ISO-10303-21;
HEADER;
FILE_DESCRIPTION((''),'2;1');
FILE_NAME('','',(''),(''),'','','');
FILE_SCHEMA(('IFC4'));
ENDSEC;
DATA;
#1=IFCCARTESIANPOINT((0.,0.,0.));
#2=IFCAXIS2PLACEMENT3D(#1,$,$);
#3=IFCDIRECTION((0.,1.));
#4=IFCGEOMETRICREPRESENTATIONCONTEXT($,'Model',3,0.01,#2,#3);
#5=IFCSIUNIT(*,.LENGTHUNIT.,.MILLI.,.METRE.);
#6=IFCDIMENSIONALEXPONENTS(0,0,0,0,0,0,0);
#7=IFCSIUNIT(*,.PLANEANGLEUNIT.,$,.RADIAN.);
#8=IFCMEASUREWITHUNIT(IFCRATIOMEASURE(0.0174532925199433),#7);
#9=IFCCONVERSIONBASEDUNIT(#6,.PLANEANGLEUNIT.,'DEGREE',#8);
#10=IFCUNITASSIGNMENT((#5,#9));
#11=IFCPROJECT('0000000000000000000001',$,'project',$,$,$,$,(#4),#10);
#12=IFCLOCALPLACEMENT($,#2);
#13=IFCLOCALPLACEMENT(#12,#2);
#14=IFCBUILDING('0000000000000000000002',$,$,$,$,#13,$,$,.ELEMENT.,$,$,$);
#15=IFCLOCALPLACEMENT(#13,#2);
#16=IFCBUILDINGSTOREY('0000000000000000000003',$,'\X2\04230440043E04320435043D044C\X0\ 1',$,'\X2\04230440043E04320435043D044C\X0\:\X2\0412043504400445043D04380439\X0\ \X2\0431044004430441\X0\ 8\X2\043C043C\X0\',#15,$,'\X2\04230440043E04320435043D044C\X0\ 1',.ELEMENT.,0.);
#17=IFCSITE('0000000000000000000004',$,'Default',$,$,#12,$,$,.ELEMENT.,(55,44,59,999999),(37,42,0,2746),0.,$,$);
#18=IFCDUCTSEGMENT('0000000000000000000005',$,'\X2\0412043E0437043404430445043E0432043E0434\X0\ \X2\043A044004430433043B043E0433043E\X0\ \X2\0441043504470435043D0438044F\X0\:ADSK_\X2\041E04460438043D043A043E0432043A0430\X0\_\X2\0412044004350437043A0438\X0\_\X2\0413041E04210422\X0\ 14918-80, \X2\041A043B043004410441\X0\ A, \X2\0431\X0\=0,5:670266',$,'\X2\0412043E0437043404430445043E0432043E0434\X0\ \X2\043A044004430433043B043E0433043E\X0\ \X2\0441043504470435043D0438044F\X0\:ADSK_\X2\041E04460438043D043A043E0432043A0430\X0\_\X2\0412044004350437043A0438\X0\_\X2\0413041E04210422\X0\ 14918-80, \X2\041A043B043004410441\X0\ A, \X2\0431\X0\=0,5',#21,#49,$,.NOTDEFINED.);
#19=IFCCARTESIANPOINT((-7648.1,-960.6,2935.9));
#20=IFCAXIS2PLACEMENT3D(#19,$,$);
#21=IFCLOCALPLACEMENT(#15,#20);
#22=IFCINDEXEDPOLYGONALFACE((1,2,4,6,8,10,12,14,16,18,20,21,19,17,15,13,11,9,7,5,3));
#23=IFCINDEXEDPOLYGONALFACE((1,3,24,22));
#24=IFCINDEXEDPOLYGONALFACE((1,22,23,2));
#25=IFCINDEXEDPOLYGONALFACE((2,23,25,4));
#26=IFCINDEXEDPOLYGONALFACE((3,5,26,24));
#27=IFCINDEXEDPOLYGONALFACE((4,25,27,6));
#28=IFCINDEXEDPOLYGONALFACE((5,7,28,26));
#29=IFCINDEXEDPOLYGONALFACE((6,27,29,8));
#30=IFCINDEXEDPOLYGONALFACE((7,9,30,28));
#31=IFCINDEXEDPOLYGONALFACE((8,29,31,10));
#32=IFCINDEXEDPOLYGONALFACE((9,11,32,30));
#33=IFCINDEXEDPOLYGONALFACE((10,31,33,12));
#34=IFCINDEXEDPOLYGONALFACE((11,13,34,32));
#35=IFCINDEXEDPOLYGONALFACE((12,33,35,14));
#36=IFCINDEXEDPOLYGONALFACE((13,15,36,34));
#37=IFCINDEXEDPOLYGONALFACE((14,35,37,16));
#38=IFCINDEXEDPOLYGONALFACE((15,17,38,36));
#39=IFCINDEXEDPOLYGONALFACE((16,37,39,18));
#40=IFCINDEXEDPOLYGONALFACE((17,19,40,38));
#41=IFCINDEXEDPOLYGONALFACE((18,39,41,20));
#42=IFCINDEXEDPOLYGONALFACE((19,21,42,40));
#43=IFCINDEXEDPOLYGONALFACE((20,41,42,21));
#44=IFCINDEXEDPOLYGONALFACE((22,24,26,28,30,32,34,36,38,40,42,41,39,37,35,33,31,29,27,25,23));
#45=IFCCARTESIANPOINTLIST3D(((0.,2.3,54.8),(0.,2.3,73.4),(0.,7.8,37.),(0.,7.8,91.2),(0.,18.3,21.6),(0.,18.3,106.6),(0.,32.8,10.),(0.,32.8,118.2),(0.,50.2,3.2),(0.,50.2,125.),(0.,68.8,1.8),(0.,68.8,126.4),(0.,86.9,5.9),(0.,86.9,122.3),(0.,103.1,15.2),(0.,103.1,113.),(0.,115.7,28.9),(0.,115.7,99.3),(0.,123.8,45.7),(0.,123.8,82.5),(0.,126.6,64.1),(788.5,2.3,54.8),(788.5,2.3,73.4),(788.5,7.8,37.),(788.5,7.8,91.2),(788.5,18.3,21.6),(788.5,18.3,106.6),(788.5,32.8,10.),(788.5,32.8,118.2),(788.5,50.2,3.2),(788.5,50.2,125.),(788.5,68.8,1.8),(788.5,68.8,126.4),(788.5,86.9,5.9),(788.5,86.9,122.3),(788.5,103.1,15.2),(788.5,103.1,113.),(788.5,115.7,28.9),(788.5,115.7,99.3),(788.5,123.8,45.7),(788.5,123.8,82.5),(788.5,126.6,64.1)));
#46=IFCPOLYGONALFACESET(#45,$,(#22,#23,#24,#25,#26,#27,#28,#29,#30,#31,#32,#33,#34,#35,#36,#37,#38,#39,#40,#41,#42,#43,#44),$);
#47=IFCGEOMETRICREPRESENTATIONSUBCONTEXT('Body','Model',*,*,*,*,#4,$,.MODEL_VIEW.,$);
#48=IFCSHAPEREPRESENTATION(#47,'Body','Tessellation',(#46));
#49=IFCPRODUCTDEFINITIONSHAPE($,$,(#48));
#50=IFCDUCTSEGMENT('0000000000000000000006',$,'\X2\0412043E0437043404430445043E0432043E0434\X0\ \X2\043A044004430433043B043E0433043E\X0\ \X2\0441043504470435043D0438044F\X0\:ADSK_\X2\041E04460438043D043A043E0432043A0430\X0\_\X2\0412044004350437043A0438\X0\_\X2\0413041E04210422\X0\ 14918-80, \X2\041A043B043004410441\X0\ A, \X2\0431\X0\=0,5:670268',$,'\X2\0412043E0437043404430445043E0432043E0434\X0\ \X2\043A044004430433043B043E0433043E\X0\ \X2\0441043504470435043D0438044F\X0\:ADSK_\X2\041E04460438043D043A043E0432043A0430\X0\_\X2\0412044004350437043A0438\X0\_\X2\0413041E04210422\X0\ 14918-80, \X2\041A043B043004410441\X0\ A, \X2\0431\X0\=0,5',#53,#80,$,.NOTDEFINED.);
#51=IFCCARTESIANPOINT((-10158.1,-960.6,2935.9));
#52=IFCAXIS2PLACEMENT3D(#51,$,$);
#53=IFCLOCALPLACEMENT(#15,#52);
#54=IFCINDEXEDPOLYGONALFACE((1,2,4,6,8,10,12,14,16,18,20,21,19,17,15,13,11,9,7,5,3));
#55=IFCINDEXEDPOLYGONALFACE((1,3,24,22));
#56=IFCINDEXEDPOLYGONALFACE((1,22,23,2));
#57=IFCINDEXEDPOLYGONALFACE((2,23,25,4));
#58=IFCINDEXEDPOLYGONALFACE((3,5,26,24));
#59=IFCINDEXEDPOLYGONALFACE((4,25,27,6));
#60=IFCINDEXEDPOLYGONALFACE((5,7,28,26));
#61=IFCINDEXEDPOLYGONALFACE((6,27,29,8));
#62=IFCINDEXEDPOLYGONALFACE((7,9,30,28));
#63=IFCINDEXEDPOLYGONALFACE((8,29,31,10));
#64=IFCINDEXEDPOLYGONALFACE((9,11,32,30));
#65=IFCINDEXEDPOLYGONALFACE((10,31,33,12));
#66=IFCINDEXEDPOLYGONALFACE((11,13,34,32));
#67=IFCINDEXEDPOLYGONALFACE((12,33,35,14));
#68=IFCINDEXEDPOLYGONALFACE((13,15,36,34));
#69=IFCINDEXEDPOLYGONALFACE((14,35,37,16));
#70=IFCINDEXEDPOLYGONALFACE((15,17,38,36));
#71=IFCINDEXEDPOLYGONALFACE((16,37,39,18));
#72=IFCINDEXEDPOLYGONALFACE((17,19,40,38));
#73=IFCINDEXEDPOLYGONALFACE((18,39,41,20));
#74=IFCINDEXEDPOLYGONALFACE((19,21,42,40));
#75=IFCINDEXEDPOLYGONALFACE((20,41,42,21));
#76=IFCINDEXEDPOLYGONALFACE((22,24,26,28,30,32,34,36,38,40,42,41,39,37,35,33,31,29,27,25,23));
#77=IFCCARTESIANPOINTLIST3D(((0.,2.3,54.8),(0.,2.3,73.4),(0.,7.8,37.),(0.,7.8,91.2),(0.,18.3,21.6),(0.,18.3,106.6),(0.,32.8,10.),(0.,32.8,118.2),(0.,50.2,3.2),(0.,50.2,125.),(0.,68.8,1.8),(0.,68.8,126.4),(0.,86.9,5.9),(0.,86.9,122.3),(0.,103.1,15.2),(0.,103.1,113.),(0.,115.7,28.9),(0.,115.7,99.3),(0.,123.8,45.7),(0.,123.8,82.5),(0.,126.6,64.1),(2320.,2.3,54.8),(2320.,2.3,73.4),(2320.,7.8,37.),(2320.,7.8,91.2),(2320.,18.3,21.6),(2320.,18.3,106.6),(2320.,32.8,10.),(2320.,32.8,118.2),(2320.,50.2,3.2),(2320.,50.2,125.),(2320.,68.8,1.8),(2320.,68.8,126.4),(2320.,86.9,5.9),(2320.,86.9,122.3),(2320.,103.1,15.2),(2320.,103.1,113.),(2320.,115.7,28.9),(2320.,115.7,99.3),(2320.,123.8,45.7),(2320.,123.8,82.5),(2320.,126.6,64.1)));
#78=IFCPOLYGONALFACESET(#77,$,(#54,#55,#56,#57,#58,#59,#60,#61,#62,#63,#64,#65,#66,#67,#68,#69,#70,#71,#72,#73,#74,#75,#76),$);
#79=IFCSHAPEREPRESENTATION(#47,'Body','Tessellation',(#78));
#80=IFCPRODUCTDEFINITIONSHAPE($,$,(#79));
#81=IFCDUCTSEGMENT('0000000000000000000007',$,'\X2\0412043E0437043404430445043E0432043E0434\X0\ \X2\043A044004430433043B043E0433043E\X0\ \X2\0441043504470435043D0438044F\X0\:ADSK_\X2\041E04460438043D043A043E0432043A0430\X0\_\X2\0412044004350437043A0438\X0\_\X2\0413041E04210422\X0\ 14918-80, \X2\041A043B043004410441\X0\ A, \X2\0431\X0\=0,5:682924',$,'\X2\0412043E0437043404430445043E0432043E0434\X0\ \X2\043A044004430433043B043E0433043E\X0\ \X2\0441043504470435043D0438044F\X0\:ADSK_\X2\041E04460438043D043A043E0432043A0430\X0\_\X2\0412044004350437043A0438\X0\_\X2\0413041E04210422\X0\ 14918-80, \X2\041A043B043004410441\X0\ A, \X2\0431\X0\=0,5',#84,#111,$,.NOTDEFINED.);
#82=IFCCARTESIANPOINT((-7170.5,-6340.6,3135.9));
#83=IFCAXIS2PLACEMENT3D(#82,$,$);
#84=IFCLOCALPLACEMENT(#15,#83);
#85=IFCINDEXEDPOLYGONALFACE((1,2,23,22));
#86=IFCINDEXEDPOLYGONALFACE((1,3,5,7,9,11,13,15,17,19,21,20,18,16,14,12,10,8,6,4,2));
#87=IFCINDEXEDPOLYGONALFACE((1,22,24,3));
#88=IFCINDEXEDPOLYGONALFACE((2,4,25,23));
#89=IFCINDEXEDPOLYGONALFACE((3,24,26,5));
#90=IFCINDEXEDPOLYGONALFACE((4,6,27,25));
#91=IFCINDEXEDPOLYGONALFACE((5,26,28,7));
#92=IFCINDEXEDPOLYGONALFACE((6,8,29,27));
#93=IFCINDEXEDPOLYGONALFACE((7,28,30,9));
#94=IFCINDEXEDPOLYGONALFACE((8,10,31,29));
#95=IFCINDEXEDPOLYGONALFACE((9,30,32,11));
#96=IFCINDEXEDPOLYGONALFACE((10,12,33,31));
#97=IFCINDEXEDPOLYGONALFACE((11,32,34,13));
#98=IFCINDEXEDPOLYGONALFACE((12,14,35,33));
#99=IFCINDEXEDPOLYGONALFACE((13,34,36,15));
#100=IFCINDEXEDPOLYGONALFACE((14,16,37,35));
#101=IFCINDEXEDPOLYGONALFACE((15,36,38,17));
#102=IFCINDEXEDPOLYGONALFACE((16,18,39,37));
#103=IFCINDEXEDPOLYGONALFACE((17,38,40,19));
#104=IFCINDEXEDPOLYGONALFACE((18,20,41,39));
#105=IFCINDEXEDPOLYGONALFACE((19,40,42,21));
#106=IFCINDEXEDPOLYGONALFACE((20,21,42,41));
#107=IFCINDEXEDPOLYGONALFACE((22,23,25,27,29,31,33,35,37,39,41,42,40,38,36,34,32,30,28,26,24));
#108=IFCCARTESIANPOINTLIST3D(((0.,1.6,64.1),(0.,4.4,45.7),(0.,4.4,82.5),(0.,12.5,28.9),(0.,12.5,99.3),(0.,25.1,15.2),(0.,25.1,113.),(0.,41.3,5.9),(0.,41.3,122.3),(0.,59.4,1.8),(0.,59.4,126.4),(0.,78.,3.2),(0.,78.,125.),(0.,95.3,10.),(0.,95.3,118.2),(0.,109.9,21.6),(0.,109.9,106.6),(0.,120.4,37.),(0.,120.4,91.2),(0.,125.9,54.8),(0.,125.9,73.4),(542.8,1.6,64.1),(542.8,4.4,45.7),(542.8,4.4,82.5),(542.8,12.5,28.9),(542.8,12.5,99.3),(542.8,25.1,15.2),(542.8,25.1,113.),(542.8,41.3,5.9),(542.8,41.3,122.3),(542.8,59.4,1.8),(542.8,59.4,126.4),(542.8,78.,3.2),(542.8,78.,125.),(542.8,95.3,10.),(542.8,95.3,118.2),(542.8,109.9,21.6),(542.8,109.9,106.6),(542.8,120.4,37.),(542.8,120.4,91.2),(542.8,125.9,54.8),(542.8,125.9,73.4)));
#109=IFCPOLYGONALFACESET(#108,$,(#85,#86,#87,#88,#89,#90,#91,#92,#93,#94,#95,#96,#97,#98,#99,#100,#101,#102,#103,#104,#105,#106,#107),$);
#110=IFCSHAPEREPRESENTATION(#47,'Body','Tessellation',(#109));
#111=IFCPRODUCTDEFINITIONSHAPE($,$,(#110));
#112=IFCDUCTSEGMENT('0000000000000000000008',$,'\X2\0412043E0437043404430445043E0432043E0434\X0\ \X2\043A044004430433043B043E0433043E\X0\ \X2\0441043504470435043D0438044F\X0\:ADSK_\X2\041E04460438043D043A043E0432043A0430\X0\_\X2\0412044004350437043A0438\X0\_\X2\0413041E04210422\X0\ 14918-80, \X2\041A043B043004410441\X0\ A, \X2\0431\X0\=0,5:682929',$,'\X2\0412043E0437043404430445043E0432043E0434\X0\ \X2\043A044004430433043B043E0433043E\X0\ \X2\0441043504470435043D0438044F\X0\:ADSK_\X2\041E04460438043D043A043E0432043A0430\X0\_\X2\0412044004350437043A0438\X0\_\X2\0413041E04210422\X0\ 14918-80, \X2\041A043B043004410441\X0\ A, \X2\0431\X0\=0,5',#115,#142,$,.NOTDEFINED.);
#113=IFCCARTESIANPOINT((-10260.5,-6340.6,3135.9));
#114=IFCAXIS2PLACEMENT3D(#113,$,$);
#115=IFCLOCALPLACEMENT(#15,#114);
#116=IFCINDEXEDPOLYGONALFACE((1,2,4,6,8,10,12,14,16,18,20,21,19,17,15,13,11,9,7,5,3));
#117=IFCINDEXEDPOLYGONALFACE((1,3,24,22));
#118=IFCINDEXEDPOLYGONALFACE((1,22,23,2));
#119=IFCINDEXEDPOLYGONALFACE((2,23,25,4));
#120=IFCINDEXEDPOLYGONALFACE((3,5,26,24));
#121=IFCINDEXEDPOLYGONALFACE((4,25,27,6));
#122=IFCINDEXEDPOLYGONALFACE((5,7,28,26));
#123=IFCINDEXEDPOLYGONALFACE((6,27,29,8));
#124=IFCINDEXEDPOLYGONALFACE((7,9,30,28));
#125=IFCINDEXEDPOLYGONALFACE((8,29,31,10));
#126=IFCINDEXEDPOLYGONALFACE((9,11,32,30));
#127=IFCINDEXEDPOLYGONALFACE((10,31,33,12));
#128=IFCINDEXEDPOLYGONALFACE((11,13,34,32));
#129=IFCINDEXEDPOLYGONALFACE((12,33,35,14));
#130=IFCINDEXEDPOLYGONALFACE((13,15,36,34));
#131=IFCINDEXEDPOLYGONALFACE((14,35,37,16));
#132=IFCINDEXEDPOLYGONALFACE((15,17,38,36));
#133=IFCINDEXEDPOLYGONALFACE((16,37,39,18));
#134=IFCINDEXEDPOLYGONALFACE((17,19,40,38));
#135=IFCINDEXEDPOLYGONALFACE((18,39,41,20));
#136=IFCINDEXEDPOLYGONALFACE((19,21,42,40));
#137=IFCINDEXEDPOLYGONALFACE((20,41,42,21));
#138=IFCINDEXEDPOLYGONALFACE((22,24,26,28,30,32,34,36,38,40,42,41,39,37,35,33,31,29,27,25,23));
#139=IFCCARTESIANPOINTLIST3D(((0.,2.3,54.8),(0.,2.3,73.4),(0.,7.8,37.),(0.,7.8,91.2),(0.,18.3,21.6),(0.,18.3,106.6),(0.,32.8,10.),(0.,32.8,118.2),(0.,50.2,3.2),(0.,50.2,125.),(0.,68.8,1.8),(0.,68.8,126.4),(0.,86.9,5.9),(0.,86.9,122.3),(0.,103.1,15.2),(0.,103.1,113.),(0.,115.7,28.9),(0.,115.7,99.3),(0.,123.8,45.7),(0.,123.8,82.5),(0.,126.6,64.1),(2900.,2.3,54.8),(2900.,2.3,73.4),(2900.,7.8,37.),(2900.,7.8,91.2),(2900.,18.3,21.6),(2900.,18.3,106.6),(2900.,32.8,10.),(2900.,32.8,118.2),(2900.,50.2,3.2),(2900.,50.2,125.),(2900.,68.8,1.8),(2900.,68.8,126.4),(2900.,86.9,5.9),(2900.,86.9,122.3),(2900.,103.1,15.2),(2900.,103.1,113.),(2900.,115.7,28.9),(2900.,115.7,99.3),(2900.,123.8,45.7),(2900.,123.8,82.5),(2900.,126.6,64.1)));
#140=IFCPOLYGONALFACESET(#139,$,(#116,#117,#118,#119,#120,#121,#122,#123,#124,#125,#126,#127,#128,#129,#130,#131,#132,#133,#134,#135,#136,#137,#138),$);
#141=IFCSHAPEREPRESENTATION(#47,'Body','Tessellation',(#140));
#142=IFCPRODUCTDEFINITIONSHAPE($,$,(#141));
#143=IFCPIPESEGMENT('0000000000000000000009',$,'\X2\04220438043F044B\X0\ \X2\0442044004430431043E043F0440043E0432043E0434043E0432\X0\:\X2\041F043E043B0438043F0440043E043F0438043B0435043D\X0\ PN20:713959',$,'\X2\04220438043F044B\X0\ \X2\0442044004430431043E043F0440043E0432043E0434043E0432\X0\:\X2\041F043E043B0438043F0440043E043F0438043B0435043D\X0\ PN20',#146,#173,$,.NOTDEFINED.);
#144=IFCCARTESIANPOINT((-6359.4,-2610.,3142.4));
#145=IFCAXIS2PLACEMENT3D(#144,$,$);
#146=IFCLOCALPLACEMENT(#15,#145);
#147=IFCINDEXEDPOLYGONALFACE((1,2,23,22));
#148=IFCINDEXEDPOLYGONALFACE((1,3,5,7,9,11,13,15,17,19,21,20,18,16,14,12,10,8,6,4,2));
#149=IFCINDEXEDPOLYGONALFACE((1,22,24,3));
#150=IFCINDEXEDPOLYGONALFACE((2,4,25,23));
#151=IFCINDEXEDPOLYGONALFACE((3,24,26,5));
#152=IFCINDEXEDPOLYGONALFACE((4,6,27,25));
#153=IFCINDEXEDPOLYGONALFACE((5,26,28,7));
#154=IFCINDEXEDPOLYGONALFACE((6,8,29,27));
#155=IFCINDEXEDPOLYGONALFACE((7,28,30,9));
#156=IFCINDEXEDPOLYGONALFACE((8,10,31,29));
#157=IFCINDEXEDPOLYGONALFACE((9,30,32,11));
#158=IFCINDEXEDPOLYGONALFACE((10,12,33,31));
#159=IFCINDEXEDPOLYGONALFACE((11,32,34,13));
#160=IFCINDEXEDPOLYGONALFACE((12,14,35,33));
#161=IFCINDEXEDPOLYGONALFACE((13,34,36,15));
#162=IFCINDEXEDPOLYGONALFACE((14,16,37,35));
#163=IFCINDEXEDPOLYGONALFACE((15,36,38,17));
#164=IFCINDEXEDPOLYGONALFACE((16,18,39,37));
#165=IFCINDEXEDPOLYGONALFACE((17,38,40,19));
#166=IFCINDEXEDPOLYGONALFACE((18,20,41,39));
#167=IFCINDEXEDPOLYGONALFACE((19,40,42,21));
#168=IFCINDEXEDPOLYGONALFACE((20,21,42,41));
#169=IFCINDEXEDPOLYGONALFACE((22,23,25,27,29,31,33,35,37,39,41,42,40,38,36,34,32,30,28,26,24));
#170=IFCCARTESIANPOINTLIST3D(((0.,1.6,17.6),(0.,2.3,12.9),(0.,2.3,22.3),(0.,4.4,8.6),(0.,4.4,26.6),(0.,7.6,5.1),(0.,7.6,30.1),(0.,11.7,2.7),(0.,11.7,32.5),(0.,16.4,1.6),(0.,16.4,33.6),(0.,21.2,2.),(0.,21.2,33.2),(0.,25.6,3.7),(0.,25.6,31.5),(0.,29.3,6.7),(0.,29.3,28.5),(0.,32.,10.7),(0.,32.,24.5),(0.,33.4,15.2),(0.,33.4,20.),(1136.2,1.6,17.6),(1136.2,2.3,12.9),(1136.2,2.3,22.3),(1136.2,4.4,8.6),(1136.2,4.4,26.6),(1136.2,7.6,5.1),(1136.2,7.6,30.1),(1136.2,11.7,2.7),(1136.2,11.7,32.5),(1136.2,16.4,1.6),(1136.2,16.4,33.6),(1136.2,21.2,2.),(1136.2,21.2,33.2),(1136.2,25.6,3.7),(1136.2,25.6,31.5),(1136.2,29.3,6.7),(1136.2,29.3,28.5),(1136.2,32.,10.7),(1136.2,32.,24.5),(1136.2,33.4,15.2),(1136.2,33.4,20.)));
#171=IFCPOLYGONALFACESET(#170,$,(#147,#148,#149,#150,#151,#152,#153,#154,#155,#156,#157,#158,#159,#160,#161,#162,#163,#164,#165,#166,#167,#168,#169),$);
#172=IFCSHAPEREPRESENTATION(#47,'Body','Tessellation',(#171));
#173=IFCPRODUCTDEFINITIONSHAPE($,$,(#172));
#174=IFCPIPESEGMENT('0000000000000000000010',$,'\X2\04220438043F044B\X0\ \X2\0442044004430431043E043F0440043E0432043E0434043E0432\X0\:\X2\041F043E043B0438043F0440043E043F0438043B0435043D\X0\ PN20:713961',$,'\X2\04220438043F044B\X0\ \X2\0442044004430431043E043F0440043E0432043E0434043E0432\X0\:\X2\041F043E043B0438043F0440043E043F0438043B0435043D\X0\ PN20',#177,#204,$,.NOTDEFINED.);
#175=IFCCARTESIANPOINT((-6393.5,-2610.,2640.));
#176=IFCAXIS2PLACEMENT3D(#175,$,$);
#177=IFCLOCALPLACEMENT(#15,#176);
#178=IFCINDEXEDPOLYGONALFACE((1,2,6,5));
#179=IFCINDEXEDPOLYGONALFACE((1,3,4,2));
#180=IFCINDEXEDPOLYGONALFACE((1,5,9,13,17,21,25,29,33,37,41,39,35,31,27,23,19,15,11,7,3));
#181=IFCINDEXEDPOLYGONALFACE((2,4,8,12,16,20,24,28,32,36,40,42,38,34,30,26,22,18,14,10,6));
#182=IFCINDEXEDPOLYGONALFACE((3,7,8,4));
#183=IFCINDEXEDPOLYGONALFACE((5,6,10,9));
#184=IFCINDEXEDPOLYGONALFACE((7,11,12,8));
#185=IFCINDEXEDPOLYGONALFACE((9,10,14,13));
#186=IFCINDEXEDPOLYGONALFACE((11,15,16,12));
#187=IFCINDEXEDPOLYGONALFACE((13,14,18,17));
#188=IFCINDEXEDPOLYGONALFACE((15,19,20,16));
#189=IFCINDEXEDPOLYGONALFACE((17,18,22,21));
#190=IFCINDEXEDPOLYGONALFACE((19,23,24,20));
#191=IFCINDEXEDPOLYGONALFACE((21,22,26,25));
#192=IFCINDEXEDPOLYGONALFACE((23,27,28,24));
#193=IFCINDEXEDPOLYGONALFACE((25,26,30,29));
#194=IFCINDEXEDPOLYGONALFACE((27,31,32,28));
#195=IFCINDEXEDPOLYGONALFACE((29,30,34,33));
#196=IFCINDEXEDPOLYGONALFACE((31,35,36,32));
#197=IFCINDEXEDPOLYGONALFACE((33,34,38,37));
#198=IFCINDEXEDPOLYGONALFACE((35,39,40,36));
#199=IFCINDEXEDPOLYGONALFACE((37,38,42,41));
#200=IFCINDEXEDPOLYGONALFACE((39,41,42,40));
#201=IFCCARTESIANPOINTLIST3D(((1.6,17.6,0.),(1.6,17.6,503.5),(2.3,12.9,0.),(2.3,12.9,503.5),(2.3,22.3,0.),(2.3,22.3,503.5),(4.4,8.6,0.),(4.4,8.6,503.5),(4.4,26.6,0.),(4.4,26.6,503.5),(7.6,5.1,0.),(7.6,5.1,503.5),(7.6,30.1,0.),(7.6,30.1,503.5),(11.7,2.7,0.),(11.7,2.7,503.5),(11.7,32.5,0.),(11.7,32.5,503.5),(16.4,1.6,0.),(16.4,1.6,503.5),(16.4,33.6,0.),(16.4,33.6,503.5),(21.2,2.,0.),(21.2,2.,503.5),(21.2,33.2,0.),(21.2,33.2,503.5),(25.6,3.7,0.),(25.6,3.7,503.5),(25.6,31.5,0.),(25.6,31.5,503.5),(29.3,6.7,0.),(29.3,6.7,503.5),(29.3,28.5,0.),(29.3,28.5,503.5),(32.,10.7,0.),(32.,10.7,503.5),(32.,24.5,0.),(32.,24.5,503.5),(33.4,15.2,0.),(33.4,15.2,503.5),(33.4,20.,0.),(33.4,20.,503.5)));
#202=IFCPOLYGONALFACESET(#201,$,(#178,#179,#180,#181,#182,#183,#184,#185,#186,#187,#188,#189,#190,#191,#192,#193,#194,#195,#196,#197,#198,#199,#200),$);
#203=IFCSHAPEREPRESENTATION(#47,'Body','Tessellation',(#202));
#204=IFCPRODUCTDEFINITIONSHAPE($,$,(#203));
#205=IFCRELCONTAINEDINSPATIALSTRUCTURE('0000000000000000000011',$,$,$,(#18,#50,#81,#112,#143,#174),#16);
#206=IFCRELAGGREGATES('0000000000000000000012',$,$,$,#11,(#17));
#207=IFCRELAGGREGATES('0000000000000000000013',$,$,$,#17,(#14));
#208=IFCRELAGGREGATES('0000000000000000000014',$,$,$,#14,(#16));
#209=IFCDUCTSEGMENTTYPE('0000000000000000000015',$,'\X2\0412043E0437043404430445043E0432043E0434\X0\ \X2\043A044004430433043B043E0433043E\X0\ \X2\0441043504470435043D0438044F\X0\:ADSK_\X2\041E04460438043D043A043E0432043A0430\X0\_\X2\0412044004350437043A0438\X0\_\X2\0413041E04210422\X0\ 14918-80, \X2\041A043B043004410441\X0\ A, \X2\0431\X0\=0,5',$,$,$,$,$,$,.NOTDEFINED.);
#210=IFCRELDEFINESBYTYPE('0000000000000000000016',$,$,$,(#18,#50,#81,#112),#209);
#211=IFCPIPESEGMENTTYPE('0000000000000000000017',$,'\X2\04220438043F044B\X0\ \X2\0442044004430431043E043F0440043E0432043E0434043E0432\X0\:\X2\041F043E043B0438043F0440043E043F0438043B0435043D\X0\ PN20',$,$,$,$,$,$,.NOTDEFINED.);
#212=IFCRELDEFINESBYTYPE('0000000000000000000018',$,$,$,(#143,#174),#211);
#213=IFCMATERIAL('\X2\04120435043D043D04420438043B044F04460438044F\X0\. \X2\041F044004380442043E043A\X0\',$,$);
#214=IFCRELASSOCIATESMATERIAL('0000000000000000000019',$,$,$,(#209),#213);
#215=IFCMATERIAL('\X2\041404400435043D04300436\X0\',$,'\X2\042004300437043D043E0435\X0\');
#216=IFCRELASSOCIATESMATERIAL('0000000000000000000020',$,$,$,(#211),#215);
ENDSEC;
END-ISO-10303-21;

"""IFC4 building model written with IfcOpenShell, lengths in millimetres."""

from ifc_helpers import new_model, entity, si_unit, converted_unit, direction, frame, frame_2d, origin, origin_2d_with_axis, place, context, subcontext, project, spatial, circle, extrude, material, type_object, element, save


model = new_model("IFC4")

# Units and contexts
model_context = context("Model", 3, precision=0.01, world=origin(), true_north=direction((0.0, 1.0)))
body_context = subcontext(model_context, "Body", "Model", "MODEL_VIEW")
ifc_project = project(units=[si_unit("LENGTHUNIT", "METRE", prefix="MILLI"), converted_unit("PLANEANGLEUNIT", "DEGREE", entity("IfcRatioMeasure", 0.0174532925199433), si_unit("PLANEANGLEUNIT", "RADIAN"), dimensions=[0, 0, 0, 0, 0, 0, 0])], contexts=[model_context])

# Site, building, storey
site_placement = place(None, origin())
site = spatial("IfcSite", under=ifc_project, at=site_placement, Name="Default", CompositionType="ELEMENT", RefLatitude=(55, 44, 59, 999999), RefLongitude=(37, 42, 0, 2746), RefElevation=0.0)
building_placement = place(site_placement, origin())
building = spatial("IfcBuilding", under=site, at=building_placement, CompositionType="ELEMENT")
storey_placement = place(building_placement, origin())
storey = spatial("IfcBuildingStorey", under=building, at=storey_placement, Name="Уровень 1", ObjectType="Уровень:Верхний брус 8мм", LongName="Уровень 1", CompositionType="ELEMENT", Elevation=0.0)

# Duct segments
ifc_material_1 = material(Name="Веннтиляция. Приток")
duct_segment_type = type_object("IfcDuctSegmentType", Name="Воздуховод круглого сечения:ADSK_Оцинковка_Врезки_ГОСТ 14918-80, Класс A, б=0,5", PredefinedType="NOTDEFINED", material=ifc_material_1)
duct_segment_1_placement = place(storey_placement, frame((-7648.1, -960.6, 2935.9)))
element("IfcDuctSegment", 1, at=duct_segment_1_placement, inside=storey, type_object=duct_segment_type, Name="Воздуховод круглого сечения:ADSK_Оцинковка_Врезки_ГОСТ 14918-80, Класс A, б=0,5:670266", ObjectType="Воздуховод круглого сечения:ADSK_Оцинковка_Врезки_ГОСТ 14918-80, Класс A, б=0,5", PredefinedType="NOTDEFINED", context=body_context, shape_type="SweptSolid", body=[
    extrude(circle(Radius=62.5, at=frame_2d((0.0, 0.0), x_axis=(1.0, 0.0))), frame((0.0, 64.1, 64.1), z_axis=(1.0, 0.0, 0.0), x_axis=(0.0, 1.0, 0.0)), (0.0, 0.0, 1.0), 788.5),
])
duct_segment_2_placement = place(storey_placement, frame((-10158.1, -960.6, 2935.9)))
element("IfcDuctSegment", 2, at=duct_segment_2_placement, inside=storey, type_object=duct_segment_type, Name="Воздуховод круглого сечения:ADSK_Оцинковка_Врезки_ГОСТ 14918-80, Класс A, б=0,5:670268", ObjectType="Воздуховод круглого сечения:ADSK_Оцинковка_Врезки_ГОСТ 14918-80, Класс A, б=0,5", PredefinedType="NOTDEFINED", context=body_context, shape_type="SweptSolid", body=[
    extrude(circle(Radius=62.5, at=frame_2d((0.0, 0.0), x_axis=(1.0, 0.0))), frame((0.0, 64.1, 64.1), z_axis=(1.0, 0.0, 0.0), x_axis=(0.0, 1.0, 0.0)), (0.0, 0.0, 1.0), 2320.0),
])
duct_segment_3_placement = place(storey_placement, frame((-7170.5, -6340.6, 3135.9)))
element("IfcDuctSegment", 3, at=duct_segment_3_placement, inside=storey, type_object=duct_segment_type, Name="Воздуховод круглого сечения:ADSK_Оцинковка_Врезки_ГОСТ 14918-80, Класс A, б=0,5:682924", ObjectType="Воздуховод круглого сечения:ADSK_Оцинковка_Врезки_ГОСТ 14918-80, Класс A, б=0,5", PredefinedType="NOTDEFINED", context=body_context, shape_type="SweptSolid", body=[
    extrude(circle(Radius=62.5, at=origin_2d_with_axis()), frame((0.0, 64.1, 64.1), z_axis=(1.0, 0.0, 0.0), x_axis=(0.0, -1.0, 0.0)), (0.0, 0.0, 1.0), 542.8),
])
duct_segment_4_placement = place(storey_placement, frame((-10260.5, -6340.6, 3135.9)))
element("IfcDuctSegment", 4, at=duct_segment_4_placement, inside=storey, type_object=duct_segment_type, Name="Воздуховод круглого сечения:ADSK_Оцинковка_Врезки_ГОСТ 14918-80, Класс A, б=0,5:682929", ObjectType="Воздуховод круглого сечения:ADSK_Оцинковка_Врезки_ГОСТ 14918-80, Класс A, б=0,5", PredefinedType="NOTDEFINED", context=body_context, shape_type="SweptSolid", body=[
    extrude(circle(Radius=62.5, at=origin_2d_with_axis()), frame((0.0, 64.1, 64.1), z_axis=(1.0, 0.0, 0.0), x_axis=(0.0, 1.0, 0.0)), (0.0, 0.0, 1.0), 2900.0),
])

# Pipe segments
ifc_material_2 = material(Name="Дренаж", Category="Разное")
pipe_segment_type_1 = type_object("IfcPipeSegmentType", Name="Типы трубопроводов:Полипропилен PN20", PredefinedType="NOTDEFINED", material=ifc_material_2)
pipe_segment_1_placement = place(storey_placement, frame((-6359.4, -2610.0, 3142.4)))
element("IfcPipeSegment", 5, at=pipe_segment_1_placement, inside=storey, type_object=pipe_segment_type_1, Name="Типы трубопроводов:Полипропилен PN20:713959", ObjectType="Типы трубопроводов:Полипропилен PN20", PredefinedType="NOTDEFINED", context=body_context, shape_type="SweptSolid", body=[
    extrude(circle(Radius=16.0, at=origin_2d_with_axis()), frame((0.0, 17.6, 17.6), z_axis=(1.0, 0.0, 0.0), x_axis=(0.0, -1.0, 0.0)), (0.0, 0.0, 1.0), 1136.2),
])
pipe_segment_2_placement = place(storey_placement, frame((-6393.5, -2610.0, 2640.0)))
element("IfcPipeSegment", 6, at=pipe_segment_2_placement, inside=storey, type_object=pipe_segment_type_1, Name="Типы трубопроводов:Полипропилен PN20:713961", ObjectType="Типы трубопроводов:Полипропилен PN20", PredefinedType="NOTDEFINED", context=body_context, shape_type="SweptSolid", body=[
    extrude(circle(Radius=16.0, at=origin_2d_with_axis()), frame((17.6, 17.6, 0.0), z_axis=(0.0, 0.0, 1.0), x_axis=(-1.0, 0.0, 0.0)), (0.0, 0.0, 1.0), 503.5),
])

save(model, "model.ifc")
